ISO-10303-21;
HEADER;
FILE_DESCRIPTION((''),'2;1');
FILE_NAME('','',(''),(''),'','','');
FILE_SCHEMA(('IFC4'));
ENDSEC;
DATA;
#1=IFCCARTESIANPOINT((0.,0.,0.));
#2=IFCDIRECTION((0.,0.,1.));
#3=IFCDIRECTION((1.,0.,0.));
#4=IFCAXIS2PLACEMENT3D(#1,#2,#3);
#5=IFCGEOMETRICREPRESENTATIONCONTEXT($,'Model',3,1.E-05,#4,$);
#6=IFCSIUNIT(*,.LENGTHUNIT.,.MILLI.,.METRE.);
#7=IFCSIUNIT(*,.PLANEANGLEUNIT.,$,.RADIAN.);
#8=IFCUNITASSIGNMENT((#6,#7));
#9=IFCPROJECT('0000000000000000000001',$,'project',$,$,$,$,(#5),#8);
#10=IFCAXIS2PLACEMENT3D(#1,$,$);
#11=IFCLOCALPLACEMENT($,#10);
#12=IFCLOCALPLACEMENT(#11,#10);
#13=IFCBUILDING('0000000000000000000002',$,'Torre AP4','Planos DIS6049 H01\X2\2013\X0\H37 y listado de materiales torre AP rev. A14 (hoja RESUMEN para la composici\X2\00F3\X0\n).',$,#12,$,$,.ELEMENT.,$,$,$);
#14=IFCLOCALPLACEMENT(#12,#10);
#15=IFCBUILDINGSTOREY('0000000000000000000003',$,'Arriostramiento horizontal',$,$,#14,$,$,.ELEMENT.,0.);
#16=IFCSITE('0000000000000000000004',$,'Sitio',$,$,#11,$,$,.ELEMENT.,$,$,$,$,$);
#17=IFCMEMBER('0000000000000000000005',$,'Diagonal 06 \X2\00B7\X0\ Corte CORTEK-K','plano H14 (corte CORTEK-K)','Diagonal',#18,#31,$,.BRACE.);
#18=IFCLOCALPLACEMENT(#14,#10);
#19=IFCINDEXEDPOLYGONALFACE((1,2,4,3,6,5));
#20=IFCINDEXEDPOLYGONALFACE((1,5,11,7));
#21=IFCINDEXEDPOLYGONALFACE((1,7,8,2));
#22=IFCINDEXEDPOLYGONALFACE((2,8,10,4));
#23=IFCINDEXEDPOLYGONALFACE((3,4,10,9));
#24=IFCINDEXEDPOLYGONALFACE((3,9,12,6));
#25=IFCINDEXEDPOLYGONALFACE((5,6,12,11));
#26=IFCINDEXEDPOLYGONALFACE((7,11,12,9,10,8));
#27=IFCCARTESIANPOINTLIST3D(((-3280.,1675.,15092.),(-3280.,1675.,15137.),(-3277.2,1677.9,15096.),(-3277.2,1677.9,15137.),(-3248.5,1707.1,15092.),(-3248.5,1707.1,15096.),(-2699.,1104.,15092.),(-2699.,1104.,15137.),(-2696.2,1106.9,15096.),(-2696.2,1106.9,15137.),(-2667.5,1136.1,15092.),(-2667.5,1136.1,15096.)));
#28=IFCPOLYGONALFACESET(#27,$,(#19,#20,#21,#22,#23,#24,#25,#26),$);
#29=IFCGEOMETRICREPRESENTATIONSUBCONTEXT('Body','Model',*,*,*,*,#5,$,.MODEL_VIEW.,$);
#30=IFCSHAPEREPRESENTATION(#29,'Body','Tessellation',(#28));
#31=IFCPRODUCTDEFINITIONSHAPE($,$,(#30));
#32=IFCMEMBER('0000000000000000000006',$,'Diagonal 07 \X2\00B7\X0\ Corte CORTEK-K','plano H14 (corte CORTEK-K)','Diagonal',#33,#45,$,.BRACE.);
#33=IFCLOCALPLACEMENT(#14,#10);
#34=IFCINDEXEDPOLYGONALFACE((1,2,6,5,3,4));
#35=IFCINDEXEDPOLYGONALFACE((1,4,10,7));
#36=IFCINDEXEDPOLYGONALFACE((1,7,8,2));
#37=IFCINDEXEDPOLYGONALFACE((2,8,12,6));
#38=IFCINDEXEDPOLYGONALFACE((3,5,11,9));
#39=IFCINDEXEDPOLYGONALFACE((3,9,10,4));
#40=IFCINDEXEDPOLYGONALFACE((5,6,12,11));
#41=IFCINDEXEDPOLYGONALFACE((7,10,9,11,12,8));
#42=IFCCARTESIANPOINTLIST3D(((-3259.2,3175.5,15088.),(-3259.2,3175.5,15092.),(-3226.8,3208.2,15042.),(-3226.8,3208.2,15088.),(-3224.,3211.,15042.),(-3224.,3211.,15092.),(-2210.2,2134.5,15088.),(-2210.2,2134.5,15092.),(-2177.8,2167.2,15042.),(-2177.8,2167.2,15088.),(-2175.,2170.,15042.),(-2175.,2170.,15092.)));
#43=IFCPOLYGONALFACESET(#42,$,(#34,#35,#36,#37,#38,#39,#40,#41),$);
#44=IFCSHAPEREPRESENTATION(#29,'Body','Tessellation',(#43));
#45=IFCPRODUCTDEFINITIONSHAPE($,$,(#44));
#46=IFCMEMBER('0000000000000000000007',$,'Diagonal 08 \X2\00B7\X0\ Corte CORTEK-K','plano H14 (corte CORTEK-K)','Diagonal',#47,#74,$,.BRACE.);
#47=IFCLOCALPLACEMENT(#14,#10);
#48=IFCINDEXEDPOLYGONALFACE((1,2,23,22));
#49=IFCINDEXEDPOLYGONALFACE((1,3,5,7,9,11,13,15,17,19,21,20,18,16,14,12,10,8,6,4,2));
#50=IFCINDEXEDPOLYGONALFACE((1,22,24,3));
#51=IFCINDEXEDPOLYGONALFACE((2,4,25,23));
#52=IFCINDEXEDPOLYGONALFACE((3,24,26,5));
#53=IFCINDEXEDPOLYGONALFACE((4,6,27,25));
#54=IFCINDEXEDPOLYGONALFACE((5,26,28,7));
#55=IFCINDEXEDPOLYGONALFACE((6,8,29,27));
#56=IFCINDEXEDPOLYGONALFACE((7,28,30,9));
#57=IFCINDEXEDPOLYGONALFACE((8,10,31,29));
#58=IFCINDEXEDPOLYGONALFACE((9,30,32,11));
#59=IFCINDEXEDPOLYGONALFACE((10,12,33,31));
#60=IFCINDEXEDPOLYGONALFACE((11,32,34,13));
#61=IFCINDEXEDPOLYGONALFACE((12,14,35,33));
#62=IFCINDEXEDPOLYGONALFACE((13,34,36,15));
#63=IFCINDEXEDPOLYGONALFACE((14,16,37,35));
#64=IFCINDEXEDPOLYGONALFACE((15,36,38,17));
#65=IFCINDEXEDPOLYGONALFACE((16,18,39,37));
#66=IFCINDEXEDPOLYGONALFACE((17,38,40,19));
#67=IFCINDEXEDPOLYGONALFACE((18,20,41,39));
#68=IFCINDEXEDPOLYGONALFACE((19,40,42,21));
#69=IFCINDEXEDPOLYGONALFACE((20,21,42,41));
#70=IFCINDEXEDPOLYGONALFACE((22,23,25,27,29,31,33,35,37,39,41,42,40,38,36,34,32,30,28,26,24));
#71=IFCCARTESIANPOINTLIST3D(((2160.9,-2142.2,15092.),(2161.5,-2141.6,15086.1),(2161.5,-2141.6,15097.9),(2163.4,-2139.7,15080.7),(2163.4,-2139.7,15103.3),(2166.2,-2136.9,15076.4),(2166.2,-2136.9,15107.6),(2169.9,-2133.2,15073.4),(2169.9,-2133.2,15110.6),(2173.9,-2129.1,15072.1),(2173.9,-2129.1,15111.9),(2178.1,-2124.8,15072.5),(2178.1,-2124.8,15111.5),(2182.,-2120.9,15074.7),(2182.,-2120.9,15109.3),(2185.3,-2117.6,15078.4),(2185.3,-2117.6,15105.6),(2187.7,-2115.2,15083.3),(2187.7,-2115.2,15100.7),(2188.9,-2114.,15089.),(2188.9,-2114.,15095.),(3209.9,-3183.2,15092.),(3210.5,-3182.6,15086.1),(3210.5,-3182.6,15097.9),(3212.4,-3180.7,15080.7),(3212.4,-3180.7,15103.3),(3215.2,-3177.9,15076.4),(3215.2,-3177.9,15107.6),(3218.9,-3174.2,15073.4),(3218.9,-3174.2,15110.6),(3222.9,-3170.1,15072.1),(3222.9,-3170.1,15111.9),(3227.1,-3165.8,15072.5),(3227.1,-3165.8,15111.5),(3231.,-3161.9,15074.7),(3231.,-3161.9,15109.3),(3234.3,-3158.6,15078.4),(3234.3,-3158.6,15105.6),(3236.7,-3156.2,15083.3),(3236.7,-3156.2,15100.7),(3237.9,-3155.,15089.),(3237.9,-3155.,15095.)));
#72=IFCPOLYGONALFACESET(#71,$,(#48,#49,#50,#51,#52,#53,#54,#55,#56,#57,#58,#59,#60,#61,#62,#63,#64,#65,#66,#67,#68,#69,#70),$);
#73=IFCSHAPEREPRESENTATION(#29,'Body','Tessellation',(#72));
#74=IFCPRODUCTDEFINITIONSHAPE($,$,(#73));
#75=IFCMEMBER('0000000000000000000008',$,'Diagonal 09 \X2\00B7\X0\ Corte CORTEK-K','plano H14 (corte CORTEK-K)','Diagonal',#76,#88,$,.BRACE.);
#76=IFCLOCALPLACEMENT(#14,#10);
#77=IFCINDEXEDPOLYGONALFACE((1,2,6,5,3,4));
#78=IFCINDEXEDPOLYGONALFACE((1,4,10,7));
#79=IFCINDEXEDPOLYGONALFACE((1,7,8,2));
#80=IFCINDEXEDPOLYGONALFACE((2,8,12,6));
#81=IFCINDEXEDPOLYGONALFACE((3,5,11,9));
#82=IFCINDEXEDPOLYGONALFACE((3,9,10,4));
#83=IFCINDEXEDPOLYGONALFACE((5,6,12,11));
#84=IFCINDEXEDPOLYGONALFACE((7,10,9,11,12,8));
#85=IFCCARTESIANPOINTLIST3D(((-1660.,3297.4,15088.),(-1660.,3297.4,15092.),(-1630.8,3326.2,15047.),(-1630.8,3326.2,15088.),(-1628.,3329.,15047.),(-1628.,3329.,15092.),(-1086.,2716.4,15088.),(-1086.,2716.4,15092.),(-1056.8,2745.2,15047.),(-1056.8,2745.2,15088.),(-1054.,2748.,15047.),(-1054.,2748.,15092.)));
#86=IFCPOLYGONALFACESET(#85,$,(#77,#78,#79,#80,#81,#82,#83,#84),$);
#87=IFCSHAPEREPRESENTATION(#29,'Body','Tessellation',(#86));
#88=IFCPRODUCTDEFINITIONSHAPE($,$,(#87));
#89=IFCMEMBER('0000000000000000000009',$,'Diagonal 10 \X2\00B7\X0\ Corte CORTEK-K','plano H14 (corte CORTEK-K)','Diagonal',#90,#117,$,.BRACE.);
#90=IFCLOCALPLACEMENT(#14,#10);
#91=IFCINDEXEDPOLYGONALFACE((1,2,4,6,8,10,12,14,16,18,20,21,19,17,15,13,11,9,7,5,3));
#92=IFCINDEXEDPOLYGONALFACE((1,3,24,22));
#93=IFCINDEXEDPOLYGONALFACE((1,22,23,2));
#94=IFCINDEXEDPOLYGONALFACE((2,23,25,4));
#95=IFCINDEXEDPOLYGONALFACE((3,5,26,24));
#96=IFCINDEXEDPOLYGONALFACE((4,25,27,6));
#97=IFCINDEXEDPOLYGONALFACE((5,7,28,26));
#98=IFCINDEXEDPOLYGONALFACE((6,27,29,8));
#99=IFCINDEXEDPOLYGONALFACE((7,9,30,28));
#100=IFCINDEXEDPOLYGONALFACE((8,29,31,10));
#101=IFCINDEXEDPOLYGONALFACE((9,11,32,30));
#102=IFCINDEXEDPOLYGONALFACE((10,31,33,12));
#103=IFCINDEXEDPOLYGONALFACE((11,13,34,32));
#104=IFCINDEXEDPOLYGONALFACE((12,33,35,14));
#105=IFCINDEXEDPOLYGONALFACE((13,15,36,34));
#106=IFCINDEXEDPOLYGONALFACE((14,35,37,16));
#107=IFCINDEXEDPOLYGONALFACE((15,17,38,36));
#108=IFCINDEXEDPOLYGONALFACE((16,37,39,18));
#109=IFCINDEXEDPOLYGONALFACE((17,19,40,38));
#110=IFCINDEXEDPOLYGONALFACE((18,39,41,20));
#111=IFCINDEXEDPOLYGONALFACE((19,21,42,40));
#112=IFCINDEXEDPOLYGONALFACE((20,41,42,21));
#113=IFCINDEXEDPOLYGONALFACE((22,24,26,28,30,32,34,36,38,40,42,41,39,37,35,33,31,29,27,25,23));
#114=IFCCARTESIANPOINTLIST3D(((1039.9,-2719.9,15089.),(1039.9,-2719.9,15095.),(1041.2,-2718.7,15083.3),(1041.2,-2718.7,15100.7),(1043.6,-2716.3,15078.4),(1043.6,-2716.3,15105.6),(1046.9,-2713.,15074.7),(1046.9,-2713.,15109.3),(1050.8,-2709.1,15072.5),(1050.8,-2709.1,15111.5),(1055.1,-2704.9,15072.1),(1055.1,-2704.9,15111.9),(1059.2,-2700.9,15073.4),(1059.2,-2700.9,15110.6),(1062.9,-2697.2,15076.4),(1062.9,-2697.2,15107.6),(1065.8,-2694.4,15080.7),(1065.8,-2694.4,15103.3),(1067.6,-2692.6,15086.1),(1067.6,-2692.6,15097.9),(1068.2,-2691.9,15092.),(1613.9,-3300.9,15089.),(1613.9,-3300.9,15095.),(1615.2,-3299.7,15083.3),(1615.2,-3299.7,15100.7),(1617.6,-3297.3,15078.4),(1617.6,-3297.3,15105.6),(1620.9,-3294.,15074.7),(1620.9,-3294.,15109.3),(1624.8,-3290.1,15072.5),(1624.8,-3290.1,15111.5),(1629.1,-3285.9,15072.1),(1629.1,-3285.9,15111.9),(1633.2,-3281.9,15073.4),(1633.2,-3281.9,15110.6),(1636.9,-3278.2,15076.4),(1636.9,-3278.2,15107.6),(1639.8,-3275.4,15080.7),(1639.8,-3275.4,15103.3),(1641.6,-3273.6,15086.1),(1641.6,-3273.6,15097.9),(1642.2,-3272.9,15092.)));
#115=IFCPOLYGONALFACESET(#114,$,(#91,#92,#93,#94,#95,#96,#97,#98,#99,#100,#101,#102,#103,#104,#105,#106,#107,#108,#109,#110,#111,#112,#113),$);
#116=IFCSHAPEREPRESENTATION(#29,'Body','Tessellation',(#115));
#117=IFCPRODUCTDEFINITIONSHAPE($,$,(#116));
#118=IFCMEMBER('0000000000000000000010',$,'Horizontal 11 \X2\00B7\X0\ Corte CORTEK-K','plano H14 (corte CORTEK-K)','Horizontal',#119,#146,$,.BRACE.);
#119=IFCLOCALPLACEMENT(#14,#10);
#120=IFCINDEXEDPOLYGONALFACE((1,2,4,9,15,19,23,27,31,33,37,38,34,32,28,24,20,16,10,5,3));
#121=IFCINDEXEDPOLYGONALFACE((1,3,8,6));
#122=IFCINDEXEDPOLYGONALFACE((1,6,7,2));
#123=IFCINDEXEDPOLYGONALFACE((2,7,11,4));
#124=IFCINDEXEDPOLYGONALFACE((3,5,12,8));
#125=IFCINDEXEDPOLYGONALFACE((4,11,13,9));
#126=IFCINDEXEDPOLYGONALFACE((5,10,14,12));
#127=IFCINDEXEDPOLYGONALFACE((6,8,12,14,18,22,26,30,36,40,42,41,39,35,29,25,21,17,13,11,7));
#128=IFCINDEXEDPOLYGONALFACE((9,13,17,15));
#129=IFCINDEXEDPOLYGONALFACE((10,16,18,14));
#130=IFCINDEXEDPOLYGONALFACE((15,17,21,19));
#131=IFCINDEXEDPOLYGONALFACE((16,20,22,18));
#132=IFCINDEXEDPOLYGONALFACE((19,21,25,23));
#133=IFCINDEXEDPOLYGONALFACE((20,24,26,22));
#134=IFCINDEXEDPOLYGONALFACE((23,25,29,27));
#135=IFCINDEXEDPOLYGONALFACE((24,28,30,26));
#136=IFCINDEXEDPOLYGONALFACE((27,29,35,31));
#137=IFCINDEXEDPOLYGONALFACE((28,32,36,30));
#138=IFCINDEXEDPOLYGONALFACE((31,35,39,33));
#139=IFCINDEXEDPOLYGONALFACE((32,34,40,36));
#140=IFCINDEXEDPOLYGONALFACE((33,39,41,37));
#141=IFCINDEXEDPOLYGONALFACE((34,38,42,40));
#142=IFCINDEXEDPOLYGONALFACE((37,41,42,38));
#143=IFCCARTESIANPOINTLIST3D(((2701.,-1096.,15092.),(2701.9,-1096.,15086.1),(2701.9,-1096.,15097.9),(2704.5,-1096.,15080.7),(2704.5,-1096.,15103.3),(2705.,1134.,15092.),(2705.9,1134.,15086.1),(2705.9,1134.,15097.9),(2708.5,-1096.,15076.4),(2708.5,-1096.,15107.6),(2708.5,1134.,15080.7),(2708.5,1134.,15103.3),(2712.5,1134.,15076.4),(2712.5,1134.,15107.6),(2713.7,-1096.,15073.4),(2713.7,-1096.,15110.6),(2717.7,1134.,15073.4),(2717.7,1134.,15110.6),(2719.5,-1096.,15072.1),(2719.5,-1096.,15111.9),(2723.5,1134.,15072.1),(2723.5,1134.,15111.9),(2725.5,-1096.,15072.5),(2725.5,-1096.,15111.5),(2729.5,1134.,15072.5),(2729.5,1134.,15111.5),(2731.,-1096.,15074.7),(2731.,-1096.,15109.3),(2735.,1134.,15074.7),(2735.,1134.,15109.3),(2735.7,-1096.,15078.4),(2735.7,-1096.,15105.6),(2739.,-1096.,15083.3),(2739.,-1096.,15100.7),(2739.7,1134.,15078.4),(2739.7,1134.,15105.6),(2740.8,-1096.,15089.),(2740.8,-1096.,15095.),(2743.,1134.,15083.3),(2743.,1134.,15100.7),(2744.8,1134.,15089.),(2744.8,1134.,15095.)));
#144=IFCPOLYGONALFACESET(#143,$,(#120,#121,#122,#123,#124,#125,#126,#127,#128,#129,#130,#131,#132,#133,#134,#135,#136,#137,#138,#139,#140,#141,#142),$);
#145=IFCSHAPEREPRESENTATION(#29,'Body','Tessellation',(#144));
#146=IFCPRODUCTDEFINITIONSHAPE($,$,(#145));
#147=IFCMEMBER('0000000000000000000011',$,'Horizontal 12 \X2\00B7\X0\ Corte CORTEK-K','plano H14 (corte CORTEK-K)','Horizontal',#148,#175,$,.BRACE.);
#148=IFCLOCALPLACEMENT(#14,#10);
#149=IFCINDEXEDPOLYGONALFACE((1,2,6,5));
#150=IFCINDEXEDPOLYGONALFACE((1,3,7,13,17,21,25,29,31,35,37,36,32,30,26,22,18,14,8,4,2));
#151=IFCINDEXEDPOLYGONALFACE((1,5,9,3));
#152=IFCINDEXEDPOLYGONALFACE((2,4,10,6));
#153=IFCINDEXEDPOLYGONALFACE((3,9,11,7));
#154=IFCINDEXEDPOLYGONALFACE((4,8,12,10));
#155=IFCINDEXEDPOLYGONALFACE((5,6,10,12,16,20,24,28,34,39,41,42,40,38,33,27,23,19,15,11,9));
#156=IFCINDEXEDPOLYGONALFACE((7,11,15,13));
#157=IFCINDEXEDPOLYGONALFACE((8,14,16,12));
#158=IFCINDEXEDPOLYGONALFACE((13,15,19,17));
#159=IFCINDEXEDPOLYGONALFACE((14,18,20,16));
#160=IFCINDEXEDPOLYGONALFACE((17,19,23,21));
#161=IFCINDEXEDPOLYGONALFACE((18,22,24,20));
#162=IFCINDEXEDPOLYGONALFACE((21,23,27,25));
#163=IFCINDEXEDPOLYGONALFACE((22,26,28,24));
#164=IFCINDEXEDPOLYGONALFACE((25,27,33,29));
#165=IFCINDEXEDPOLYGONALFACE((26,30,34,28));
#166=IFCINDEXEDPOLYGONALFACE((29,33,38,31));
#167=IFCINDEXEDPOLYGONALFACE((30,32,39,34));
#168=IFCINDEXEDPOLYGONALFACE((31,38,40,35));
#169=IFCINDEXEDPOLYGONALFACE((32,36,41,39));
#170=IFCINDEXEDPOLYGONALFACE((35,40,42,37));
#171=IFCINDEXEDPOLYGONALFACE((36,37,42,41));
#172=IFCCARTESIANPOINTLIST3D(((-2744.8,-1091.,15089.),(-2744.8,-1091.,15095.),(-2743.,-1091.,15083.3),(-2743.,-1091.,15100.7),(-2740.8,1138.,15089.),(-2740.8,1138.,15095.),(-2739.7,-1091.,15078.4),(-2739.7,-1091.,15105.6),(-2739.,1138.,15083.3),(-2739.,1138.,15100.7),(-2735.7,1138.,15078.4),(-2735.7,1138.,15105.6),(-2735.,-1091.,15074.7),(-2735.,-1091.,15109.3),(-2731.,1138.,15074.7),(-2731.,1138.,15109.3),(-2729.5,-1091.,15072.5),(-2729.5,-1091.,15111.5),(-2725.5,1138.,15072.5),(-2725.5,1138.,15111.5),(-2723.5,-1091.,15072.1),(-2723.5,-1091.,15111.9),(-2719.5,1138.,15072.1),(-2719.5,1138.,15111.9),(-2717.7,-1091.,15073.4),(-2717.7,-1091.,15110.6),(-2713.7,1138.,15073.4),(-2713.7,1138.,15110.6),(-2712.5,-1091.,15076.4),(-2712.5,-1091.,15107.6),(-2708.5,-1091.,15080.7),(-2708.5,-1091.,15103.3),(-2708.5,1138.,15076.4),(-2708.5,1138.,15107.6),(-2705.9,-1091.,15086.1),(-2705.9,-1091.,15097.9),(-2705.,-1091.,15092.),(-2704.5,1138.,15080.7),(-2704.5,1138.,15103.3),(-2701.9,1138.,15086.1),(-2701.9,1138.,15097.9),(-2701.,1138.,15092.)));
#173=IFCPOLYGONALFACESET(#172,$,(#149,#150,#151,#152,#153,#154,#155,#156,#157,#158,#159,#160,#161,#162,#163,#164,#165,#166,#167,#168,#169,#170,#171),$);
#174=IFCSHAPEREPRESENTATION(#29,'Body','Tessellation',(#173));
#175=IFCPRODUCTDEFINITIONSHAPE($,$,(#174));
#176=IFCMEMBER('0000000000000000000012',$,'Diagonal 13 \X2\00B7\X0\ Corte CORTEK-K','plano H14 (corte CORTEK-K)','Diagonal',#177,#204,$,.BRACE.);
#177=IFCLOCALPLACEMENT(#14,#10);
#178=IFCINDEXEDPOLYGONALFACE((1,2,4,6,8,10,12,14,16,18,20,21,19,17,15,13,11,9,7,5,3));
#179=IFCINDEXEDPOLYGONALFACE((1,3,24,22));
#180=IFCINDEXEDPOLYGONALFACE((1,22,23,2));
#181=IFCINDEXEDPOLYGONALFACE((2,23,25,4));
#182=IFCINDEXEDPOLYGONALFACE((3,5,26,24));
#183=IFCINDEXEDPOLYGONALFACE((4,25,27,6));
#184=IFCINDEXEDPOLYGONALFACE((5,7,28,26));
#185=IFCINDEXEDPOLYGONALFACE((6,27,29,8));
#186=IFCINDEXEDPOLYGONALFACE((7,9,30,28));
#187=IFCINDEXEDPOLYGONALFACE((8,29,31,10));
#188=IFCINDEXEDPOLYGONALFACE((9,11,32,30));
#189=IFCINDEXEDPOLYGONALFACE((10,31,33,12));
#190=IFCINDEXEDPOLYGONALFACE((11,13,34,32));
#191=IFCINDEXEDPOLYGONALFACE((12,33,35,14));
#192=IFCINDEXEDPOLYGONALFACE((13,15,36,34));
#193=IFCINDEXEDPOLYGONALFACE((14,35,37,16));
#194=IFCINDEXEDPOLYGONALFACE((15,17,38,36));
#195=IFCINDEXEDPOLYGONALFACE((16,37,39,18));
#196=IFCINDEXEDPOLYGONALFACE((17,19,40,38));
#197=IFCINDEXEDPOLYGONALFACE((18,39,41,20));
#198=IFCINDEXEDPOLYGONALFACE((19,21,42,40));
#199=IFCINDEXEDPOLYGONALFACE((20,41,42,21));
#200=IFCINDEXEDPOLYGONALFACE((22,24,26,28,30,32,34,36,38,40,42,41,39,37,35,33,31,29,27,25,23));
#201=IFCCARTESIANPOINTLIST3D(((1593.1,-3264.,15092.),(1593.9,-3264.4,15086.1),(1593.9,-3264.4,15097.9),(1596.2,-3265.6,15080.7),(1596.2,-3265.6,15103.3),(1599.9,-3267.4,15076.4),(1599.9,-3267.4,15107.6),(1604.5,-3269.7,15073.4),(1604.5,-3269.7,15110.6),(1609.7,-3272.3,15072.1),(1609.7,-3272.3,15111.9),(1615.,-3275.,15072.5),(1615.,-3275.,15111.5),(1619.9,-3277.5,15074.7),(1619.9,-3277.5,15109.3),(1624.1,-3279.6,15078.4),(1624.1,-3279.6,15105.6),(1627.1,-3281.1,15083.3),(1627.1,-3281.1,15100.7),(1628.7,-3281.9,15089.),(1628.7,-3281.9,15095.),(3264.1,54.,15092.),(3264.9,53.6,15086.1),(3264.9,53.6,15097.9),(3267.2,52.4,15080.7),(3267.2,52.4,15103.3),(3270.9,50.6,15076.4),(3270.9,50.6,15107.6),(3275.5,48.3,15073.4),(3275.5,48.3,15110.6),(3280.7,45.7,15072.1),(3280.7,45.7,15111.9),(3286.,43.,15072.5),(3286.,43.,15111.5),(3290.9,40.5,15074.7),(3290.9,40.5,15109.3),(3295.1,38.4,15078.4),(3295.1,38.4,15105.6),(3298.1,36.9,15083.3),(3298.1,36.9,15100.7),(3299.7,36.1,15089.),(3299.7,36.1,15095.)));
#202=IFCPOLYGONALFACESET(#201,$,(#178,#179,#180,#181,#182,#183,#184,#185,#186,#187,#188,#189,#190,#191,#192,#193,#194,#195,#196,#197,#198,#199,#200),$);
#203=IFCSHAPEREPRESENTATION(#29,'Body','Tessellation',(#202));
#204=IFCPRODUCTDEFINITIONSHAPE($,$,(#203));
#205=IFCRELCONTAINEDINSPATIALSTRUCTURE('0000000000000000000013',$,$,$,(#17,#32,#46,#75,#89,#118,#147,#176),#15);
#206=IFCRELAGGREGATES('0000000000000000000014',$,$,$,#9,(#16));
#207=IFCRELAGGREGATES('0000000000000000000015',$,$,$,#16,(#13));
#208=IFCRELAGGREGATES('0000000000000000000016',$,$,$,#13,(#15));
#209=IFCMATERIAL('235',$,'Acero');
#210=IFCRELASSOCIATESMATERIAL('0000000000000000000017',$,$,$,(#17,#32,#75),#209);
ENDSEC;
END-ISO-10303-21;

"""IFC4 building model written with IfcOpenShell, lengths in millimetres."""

from ifc_helpers import new_model, si_unit, frame, frame_2d, origin, origin_with_axes, place, context, subcontext, project, spatial, circle, l_section, extrude, material, element, save


model = new_model("IFC4")

# Units and contexts
model_context = context("Model", 3, precision=1e-05, world=origin_with_axes())
body_context = subcontext(model_context, "Body", "Model", "MODEL_VIEW")
ifc_project = project(units=[si_unit("LENGTHUNIT", "METRE", prefix="MILLI"), si_unit("PLANEANGLEUNIT", "RADIAN")], contexts=[model_context])

# Site, building, storey
site_placement = place(None, origin())
site = spatial("IfcSite", under=ifc_project, at=site_placement, Name="Sitio", CompositionType="ELEMENT")
building_placement = place(site_placement, origin())
building = spatial("IfcBuilding", under=site, at=building_placement, Name="Torre AP4", Description="Planos DIS6049 H01–H37 y listado de materiales torre AP rev. A14 (hoja RESUMEN para la composición).", CompositionType="ELEMENT")
storey_placement = place(building_placement, origin())
storey = spatial("IfcBuildingStorey", under=building, at=storey_placement, Name="Arriostramiento horizontal", CompositionType="ELEMENT", Elevation=0.0)

# Members
ifc_material = material(Name="235", Category="Acero")
member_1_placement = place(storey_placement, frame((-3280.0, 1675.0, 15092.0), z_axis=(0.713218, -0.700942, 0.0), x_axis=(0.700942, 0.713218, 0.0)))
element("IfcMember", 1, at=member_1_placement, inside=storey, material=ifc_material, Name="Diagonal 06 · Corte CORTEK-K", Description="plano H14 (corte CORTEK-K)", ObjectType="Diagonal", PredefinedType="BRACE", context=body_context, shape_type="SweptSolid", body=[
    extrude(l_section(Depth=45.0, Width=45.0, Thickness=4.0, at=frame_2d((22.5, 22.5))), None, (0.0, 0.0, 1.0), 814.6),
])
member_2_placement = place(storey_placement, frame((-3224.0, 3211.0, 15092.0), z_axis=(0.709808, -0.704395, 0.0), x_axis=(-0.704395, -0.709808, 0.0)))
element("IfcMember", 2, at=member_2_placement, inside=storey, material=ifc_material, Name="Diagonal 07 · Corte CORTEK-K", Description="plano H14 (corte CORTEK-K)", ObjectType="Diagonal", PredefinedType="BRACE", context=body_context, shape_type="SweptSolid", body=[
    extrude(l_section(Depth=50.0, Width=50.0, Thickness=4.0, at=frame_2d((25.0, 25.0))), None, (0.0, 0.0, 1.0), 1477.9),
])
member_3_placement = place(storey_placement, frame((2175.0, -2128.0, 15092.0), z_axis=(0.709808, -0.704395, 0.0), x_axis=(-0.704395, -0.709808, 0.0)))
element("IfcMember", 3, at=member_3_placement, inside=storey, Name="Diagonal 08 · Corte CORTEK-K", Description="plano H14 (corte CORTEK-K)", ObjectType="Diagonal", PredefinedType="BRACE", context=body_context, shape_type="SweptSolid", body=[
    extrude(circle(Radius=20.0), None, (0.0, 0.0, 1.0), 1477.9),
])
member_4_placement = place(storey_placement, frame((-1628.0, 3329.0, 15092.0), z_axis=(0.702808, -0.711379, 0.0), x_axis=(-0.711379, -0.702808, 0.0)))
element("IfcMember", 4, at=member_4_placement, inside=storey, material=ifc_material, Name="Diagonal 09 · Corte CORTEK-K", Description="plano H14 (corte CORTEK-K)", ObjectType="Diagonal", PredefinedType="BRACE", context=body_context, shape_type="SweptSolid", body=[
    extrude(l_section(Depth=45.0, Width=45.0, Thickness=4.0, at=frame_2d((22.5, 22.5))), None, (0.0, 0.0, 1.0), 816.7),
])
member_5_placement = place(storey_placement, frame((1054.0, -2706.0, 15092.0), z_axis=(0.702808, -0.711379, 0.0), x_axis=(0.711379, 0.702808, 0.0)))
element("IfcMember", 5, at=member_5_placement, inside=storey, Name="Diagonal 10 · Corte CORTEK-K", Description="plano H14 (corte CORTEK-K)", ObjectType="Diagonal", PredefinedType="BRACE", context=body_context, shape_type="SweptSolid", body=[
    extrude(circle(Radius=20.0), None, (0.0, 0.0, 1.0), 816.7),
])
member_6_placement = place(storey_placement, frame((2725.0, 1134.0, 15092.0), z_axis=(-0.001794, -0.999998, 0.0), x_axis=(-0.999998, 0.001794, 0.0)))
element("IfcMember", 6, at=member_6_placement, inside=storey, Name="Horizontal 11 · Corte CORTEK-K", Description="plano H14 (corte CORTEK-K)", ObjectType="Horizontal", PredefinedType="BRACE", context=body_context, shape_type="SweptSolid", body=[
    extrude(circle(Radius=20.0), None, (0.0, 0.0, 1.0), 2230.0),
])
member_7_placement = place(storey_placement, frame((-2721.0, 1138.0, 15092.0), z_axis=(-0.001795, -0.999998, 0.0), x_axis=(0.999998, -0.001795, 0.0)))
element("IfcMember", 7, at=member_7_placement, inside=storey, Name="Horizontal 12 · Corte CORTEK-K", Description="plano H14 (corte CORTEK-K)", ObjectType="Horizontal", PredefinedType="BRACE", context=body_context, shape_type="SweptSolid", body=[
    extrude(circle(Radius=20.0), None, (0.0, 0.0, 1.0), 2229.0),
])
member_8_placement = place(storey_placement, frame((3282.0, 45.0, 15092.0), z_axis=(-0.449796, -0.893131, 0.0), x_axis=(-0.893131, 0.449796, 0.0)))
element("IfcMember", 8, at=member_8_placement, inside=storey, Name="Diagonal 13 · Corte CORTEK-K", Description="plano H14 (corte CORTEK-K)", ObjectType="Diagonal", PredefinedType="BRACE", context=body_context, shape_type="SweptSolid", body=[
    extrude(circle(Radius=20.0), None, (0.0, 0.0, 1.0), 3715.0),
])

save(model, "model.ifc")
